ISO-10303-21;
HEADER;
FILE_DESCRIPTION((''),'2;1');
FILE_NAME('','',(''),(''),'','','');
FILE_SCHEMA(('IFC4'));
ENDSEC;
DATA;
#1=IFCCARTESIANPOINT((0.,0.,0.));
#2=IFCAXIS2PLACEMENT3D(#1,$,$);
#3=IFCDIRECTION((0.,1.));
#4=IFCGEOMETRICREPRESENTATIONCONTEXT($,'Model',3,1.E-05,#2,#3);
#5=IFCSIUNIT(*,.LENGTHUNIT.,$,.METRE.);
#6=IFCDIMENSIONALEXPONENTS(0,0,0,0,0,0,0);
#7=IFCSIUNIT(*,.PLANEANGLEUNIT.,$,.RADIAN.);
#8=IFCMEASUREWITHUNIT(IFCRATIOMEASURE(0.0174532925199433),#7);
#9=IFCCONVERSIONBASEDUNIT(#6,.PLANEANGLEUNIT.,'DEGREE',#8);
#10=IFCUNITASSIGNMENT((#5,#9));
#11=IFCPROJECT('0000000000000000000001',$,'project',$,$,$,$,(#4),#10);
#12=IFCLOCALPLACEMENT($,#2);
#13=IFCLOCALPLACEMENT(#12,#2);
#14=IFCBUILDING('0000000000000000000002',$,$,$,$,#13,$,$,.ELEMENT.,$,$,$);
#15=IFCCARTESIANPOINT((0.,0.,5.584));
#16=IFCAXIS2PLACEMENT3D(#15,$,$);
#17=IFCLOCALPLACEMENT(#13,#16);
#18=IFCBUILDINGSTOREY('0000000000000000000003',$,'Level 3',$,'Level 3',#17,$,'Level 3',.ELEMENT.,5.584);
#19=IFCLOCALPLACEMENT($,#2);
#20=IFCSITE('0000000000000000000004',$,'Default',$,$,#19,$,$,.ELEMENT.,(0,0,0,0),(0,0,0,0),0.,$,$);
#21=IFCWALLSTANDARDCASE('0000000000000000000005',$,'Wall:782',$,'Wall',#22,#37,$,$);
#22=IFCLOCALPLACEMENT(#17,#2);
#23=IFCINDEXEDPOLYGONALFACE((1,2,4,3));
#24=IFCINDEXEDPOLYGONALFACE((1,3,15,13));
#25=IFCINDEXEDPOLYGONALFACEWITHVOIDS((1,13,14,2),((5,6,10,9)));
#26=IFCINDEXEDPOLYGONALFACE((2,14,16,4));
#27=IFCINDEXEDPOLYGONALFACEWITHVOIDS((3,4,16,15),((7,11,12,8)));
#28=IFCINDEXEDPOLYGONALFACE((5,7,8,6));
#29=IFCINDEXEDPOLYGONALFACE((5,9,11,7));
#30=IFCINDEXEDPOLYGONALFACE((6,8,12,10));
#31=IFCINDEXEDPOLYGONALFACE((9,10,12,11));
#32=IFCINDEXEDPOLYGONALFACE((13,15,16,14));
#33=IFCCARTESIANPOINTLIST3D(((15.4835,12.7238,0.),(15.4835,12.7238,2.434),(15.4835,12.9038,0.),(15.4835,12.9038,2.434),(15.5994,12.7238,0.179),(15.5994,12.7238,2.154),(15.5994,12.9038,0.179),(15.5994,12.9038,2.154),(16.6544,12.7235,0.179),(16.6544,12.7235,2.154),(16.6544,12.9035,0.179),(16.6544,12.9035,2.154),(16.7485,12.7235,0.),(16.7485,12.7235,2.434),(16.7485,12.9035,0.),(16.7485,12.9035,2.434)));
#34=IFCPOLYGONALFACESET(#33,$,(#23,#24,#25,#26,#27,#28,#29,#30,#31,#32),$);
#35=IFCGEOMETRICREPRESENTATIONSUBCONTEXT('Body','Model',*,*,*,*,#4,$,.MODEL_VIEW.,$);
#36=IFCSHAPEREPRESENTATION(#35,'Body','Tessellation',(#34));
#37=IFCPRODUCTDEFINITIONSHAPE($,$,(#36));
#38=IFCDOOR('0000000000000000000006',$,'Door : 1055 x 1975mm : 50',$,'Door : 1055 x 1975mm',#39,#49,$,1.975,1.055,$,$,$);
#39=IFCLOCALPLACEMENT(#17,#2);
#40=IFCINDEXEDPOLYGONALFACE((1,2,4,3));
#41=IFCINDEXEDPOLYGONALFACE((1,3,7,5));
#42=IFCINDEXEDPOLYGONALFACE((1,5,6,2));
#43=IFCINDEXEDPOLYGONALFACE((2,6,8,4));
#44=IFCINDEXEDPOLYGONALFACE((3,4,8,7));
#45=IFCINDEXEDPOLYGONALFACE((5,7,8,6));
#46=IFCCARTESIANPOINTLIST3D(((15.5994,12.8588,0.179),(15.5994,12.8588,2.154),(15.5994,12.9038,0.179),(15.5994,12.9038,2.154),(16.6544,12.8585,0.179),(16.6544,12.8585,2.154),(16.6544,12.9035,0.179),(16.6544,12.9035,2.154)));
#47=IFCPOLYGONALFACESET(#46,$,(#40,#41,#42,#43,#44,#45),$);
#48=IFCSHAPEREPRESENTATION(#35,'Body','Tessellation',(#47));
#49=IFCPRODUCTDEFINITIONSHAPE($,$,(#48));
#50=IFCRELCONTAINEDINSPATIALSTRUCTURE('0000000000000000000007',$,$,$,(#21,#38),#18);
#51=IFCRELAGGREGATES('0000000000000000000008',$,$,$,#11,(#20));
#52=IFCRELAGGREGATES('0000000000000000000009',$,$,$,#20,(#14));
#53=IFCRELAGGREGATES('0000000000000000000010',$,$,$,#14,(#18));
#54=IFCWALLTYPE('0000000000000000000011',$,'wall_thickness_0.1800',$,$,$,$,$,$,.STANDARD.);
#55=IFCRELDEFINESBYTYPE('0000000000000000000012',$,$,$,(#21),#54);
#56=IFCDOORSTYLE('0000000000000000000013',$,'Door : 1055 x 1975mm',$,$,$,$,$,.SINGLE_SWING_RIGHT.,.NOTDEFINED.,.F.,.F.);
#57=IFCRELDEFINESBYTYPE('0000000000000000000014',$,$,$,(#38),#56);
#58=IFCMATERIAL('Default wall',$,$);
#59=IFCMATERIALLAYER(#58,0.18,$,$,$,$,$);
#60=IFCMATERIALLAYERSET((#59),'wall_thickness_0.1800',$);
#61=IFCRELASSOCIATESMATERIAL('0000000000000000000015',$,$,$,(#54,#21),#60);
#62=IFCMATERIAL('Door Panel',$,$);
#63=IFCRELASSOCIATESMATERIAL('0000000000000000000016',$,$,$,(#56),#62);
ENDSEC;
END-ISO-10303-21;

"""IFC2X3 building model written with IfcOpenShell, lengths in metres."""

from ifc_helpers import new_model, entity, si_unit, converted_unit, direction, frame, frame_2d, origin, origin_2d_with_axis, place, context, subcontext, project, spatial, polyline, rectangle, outline, extrude, source, transform, mapped, material, layer, layer_set, layer_usage, type_object, type_shapes, element, fill, save


model = new_model("IFC2X3")

# Units and contexts
model_context = context("Model", 3, precision=1e-05, world=origin(), true_north=direction((0.0, 1.0)))
body_context = subcontext(model_context, "Body", "Model", "MODEL_VIEW")
ifc_project = project(units=[si_unit("LENGTHUNIT", "METRE"), converted_unit("PLANEANGLEUNIT", "DEGREE", entity("IfcRatioMeasure", 0.0174532925199433), si_unit("PLANEANGLEUNIT", "RADIAN"), dimensions=[0, 0, 0, 0, 0, 0, 0])], contexts=[model_context])

# Site, building, storey
site_placement = place(None, origin())
site = spatial("IfcSite", under=ifc_project, at=site_placement, Name="Default", CompositionType="ELEMENT", RefLatitude=(0, 0, 0, 0), RefLongitude=(0, 0, 0, 0), RefElevation=0.0)
placement_1 = place(None, origin())
building_placement = place(placement_1, origin())
building = spatial("IfcBuilding", under=site, at=building_placement, CompositionType="ELEMENT")
storey_placement = place(building_placement, frame((0.0, 0.0, 5.584)))
storey = spatial("IfcBuildingStorey", under=building, at=storey_placement, Name="Level 3", ObjectType="Level 3", LongName="Level 3", CompositionType="ELEMENT", Elevation=5.584)

# Shared definitions
ifc_material_1 = material(Name="Default wall")

# Wall, opening, door
ifc_layer_1 = layer(ifc_material_1, 0.18)
ifc_layer_set_1 = layer_set([ifc_layer_1], Name="wall_thickness_0.1800")
ifc_layer_usage_1 = layer_usage(ifc_layer_set_1, "AXIS2", "POSITIVE", -0.09)
wall_type_1 = type_object("IfcWallType", Name="wall_thickness_0.1800", PredefinedType="STANDARD", material=ifc_layer_set_1)
wall_1_placement = place(storey_placement, frame((15.4835, 12.8138, 0.0), z_axis=(0.0, 0.0, 1.0), x_axis=(1.0, -0.000216, 0.0)))
wall_1 = element("IfcWallStandardCase", 1, at=wall_1_placement, inside=storey, type_object=wall_type_1, material=ifc_layer_usage_1, Name="Wall:782", ObjectType="Wall", context=body_context, shape_type="SweptSolid", body=[
    extrude(outline(polyline([(1.265, -0.09), (1.265, 0.09), (0.0, 0.09), (0.0, -0.09), (1.265, -0.09)])), origin(), (0.0, 0.0, 1.0), 2.434),
])
opening_1_placement = place(wall_1_placement, frame((0.1159, -0.09, 0.179)))
opening_1 = element("IfcOpeningElement", 2, at=opening_1_placement, cuts=wall_1, ObjectType="Opening", context=body_context, shape_type="SweptSolid", body=[
    extrude(rectangle(XDim=1.055, YDim=1.975, at=frame_2d((0.9875, 0.5275), x_axis=(0.0, 1.0))), frame((0.0, 0.0, 0.0), z_axis=(0.0, 1.0, 0.0), x_axis=(0.0, 0.0, 1.0)), (0.0, 0.0, 1.0), 0.18),
])
ifc_material_2 = material(Name="Door Panel")
door_style = type_object("IfcDoorStyle", Name="Door : 1055 x 1975mm", ConstructionType="NOTDEFINED", OperationType="SINGLE_SWING_RIGHT", ParameterTakesPrecedence=False, Sizeable=False, material=ifc_material_2)
shared_shape_1 = source(origin(), body_context, "Body", "SweptSolid", [
    extrude(rectangle(XDim=0.045, YDim=1.055, at=origin_2d_with_axis()), frame((0.5275, 0.1575, 0.0), z_axis=(0.0, 0.0, 1.0), x_axis=(0.0, 1.0, 0.0)), (0.0, 0.0, 1.0), 1.975),
])
type_shapes(door_style, [shared_shape_1])
door_placement = place(opening_1_placement, origin())
door = element("IfcDoor", 3, at=door_placement, inside=storey, type_object=door_style, Name="Door : 1055 x 1975mm : 50", ObjectType="Door : 1055 x 1975mm", OverallHeight=1.975, OverallWidth=1.055, context=body_context, shape_type="MappedRepresentation", body=[
    mapped(shared_shape_1, transform((0.0, 0.0, 0.0), scale=1.0)),
])
fill(opening_1, door)

save(model, "model.ifc")
